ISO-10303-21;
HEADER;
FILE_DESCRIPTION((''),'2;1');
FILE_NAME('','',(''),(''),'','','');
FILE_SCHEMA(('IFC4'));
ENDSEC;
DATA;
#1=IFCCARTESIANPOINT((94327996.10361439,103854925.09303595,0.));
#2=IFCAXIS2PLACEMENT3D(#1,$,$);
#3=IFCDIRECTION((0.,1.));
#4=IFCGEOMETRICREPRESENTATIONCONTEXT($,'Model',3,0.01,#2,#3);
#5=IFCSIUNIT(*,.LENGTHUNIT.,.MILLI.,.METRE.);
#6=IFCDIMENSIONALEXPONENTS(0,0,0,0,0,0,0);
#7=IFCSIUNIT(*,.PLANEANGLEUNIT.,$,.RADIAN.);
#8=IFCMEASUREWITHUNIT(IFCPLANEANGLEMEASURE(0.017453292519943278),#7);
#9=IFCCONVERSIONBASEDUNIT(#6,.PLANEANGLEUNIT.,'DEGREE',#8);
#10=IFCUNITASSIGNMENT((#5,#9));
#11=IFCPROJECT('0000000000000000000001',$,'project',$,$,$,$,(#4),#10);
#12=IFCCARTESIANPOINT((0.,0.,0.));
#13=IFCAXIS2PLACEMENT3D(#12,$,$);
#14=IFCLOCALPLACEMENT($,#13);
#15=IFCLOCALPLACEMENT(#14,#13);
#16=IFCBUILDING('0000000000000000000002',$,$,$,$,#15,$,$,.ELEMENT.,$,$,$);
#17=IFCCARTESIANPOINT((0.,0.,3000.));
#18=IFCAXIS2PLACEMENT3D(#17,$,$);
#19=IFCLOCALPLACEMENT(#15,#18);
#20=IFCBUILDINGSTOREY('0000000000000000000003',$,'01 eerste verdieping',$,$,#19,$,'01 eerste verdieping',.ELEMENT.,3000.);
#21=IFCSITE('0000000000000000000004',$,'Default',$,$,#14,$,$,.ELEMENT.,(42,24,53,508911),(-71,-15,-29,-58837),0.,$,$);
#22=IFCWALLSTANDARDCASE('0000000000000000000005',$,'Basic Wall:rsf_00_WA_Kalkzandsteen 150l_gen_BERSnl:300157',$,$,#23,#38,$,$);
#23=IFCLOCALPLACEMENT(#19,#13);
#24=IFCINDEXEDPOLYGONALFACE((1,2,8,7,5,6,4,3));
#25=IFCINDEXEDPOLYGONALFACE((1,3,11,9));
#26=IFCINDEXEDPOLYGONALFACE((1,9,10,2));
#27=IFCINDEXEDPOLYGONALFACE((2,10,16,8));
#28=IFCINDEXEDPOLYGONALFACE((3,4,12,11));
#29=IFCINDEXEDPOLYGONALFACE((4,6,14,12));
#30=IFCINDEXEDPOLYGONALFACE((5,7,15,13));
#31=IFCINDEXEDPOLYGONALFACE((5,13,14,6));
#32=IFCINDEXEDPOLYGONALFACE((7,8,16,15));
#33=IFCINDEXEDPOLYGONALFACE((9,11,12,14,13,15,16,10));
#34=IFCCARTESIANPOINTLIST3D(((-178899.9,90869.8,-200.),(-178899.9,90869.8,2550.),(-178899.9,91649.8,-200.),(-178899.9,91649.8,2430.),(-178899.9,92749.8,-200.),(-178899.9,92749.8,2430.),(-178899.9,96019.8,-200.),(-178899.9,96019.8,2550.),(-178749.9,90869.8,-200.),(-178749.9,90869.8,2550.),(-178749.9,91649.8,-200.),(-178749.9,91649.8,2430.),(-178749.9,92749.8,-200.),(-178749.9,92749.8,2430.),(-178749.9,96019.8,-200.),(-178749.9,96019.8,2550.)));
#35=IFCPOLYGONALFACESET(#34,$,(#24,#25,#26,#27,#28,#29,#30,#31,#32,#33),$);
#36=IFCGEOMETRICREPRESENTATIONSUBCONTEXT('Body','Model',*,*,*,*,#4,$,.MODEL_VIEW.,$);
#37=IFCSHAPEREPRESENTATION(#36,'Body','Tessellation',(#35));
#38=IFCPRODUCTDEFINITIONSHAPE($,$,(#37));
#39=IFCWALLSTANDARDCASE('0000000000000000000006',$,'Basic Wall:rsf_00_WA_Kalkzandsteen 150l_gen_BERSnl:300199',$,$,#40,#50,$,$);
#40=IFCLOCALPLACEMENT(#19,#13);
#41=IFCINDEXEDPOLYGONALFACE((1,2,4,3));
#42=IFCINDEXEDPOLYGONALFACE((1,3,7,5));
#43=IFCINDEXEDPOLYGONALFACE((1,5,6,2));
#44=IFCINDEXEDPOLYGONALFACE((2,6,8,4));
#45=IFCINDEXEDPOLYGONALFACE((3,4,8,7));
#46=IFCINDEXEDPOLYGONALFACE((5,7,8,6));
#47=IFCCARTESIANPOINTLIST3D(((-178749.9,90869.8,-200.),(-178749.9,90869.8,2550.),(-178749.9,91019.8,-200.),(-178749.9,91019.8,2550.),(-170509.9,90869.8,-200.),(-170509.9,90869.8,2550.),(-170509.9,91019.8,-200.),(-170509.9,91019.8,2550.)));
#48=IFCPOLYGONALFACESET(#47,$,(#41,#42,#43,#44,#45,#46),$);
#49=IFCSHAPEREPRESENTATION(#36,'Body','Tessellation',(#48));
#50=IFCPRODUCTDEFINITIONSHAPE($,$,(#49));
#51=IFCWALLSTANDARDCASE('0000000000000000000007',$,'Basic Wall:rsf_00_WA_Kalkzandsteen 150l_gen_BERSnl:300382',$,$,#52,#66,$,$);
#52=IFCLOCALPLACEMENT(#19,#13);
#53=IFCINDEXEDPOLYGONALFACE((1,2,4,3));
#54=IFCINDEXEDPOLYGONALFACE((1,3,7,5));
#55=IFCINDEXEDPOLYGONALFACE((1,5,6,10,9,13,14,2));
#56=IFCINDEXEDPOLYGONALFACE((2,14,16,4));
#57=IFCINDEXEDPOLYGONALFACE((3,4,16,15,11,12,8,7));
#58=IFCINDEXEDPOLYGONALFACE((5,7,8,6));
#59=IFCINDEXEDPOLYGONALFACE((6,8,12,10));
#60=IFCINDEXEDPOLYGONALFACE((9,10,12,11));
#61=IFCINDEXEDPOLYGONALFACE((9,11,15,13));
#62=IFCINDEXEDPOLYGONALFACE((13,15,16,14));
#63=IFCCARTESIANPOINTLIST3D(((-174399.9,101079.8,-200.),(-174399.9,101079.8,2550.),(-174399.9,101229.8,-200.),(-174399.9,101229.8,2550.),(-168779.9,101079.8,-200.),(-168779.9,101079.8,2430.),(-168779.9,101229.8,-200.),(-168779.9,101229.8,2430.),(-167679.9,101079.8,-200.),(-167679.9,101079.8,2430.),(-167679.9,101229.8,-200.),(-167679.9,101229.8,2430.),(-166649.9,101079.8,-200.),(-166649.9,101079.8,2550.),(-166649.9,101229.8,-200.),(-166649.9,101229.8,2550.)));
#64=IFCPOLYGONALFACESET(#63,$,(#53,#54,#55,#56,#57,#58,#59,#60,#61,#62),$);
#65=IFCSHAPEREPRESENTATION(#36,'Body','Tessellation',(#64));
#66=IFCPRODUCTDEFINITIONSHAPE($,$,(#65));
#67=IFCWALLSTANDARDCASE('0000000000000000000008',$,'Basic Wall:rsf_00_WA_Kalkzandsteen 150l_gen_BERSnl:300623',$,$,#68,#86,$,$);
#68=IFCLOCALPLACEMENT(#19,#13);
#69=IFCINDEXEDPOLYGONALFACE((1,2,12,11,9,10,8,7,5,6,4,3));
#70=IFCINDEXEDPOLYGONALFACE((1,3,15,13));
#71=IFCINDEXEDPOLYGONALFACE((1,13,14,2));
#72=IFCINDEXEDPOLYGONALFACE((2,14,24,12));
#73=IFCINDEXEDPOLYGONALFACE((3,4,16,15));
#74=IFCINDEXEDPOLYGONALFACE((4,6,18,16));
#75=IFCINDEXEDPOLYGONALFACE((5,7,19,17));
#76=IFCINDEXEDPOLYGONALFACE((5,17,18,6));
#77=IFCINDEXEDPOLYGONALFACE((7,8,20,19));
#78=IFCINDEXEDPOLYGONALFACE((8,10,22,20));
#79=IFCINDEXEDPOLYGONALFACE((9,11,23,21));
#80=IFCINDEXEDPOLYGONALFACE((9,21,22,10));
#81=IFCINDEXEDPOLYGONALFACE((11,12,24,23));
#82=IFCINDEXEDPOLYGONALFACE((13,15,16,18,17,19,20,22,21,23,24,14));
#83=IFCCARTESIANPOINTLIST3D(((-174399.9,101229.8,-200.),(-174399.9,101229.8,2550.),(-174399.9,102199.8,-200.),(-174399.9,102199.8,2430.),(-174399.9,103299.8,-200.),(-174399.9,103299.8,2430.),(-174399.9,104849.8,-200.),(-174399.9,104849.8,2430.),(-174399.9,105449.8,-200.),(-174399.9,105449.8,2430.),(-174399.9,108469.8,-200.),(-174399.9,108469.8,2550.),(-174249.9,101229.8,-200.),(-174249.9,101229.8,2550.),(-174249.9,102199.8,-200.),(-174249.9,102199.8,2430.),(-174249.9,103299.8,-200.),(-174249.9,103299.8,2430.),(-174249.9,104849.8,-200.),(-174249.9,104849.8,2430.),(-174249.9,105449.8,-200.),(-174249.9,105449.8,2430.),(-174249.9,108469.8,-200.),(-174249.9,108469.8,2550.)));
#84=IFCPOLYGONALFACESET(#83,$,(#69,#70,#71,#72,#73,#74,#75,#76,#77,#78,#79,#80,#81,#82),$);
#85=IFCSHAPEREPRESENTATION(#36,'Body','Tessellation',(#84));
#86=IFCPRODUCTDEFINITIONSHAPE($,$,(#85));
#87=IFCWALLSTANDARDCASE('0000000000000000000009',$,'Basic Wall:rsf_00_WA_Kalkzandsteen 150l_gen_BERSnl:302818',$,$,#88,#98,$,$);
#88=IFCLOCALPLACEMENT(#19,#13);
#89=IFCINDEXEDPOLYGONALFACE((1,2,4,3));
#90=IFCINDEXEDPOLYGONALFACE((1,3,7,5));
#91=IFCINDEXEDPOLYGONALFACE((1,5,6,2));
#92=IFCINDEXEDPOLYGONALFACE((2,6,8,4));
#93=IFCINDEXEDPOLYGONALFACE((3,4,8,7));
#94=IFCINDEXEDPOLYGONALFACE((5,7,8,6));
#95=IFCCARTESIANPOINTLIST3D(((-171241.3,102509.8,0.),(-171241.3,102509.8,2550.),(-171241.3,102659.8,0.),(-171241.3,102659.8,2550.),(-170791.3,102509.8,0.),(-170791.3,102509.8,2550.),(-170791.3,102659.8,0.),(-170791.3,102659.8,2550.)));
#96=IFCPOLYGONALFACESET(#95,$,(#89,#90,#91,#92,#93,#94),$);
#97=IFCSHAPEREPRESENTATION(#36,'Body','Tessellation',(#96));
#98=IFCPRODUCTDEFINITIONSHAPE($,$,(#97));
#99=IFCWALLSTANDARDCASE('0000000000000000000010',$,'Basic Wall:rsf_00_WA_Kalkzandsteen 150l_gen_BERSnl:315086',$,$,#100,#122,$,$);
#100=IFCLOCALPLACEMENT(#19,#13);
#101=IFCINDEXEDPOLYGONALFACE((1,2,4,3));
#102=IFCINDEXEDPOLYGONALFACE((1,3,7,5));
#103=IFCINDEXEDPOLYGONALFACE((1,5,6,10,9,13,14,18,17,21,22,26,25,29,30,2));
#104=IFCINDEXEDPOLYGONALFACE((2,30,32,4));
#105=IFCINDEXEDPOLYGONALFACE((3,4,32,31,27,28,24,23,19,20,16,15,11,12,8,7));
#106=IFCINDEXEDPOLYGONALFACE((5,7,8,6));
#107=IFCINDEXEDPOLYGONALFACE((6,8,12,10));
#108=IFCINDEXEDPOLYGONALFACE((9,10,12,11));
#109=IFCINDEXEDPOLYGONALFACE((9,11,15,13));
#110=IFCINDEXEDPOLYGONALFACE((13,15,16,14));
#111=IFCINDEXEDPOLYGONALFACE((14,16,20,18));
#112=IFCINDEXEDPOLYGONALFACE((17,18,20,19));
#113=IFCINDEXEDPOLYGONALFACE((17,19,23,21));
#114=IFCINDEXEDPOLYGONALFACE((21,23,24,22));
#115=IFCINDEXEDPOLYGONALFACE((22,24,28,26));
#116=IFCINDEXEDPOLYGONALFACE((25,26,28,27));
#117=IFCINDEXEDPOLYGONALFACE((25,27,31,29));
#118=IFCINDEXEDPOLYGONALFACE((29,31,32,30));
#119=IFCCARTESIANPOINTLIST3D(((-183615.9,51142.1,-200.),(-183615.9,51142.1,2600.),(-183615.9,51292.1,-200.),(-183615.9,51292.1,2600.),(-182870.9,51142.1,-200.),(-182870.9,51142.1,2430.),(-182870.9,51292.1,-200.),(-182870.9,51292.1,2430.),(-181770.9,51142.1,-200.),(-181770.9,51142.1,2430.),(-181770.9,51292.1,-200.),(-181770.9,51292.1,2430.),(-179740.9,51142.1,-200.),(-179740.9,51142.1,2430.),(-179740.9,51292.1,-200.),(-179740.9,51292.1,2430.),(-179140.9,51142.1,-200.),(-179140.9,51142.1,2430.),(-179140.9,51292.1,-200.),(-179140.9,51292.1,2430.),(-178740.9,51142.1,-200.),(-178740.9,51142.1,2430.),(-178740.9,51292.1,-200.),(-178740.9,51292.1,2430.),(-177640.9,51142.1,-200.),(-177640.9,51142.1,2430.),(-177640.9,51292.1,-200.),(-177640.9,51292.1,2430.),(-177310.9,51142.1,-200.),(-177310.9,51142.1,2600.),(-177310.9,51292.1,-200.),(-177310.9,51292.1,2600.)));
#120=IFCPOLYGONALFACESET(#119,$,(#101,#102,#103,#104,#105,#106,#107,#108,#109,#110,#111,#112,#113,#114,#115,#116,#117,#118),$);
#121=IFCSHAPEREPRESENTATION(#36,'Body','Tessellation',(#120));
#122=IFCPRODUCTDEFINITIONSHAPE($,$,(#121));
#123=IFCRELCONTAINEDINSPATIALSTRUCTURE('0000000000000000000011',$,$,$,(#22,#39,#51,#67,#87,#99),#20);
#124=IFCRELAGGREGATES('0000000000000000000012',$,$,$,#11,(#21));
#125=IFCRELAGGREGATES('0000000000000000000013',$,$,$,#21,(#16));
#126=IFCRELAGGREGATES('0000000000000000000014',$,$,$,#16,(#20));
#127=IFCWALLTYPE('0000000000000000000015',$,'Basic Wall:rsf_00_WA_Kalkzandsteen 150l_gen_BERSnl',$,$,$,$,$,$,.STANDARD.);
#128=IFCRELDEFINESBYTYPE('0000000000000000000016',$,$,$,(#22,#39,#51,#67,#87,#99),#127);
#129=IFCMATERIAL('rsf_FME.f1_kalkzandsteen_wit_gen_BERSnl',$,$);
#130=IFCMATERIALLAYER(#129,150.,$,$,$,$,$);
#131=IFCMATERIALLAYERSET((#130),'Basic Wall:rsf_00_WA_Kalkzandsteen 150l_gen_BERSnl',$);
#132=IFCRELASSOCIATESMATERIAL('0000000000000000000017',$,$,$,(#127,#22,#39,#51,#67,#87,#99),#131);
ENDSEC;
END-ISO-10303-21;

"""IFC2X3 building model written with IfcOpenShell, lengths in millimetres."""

from ifc_helpers import new_model, entity, si_unit, converted_unit, direction, frame, frame_2d, origin, origin_2d_with_axis, place, context, subcontext, project, spatial, polyline, rectangle, extrude, clip, bounded_halfspace, material, layer, layer_set, layer_usage, type_object, element, save


model = new_model("IFC2X3")

# Units and contexts
model_context = context("Model", 3, precision=0.01, world=frame((94327996.10361439, 103854925.09303595, 0.0)), true_north=direction((0.0, 1.0)))
body_context = subcontext(model_context, "Body", "Model", "MODEL_VIEW")
ifc_project = project(units=[si_unit("LENGTHUNIT", "METRE", prefix="MILLI"), converted_unit("PLANEANGLEUNIT", "DEGREE", entity("IfcPlaneAngleMeasure", 0.017453292519943278), si_unit("PLANEANGLEUNIT", "RADIAN"), dimensions=[0, 0, 0, 0, 0, 0, 0])], contexts=[model_context])

# Site, building, storey
site_placement = place(None, origin())
site = spatial("IfcSite", under=ifc_project, at=site_placement, Name="Default", CompositionType="ELEMENT", RefLatitude=(42, 24, 53, 508911), RefLongitude=(-71, -15, -29, -58837), RefElevation=0.0)
building_placement = place(site_placement, origin())
building = spatial("IfcBuilding", under=site, at=building_placement, CompositionType="ELEMENT")
storey_placement = place(building_placement, frame((0.0, 0.0, 3000.0)))
storey = spatial("IfcBuildingStorey", under=building, at=storey_placement, Name="01 eerste verdieping", LongName="01 eerste verdieping", CompositionType="ELEMENT", Elevation=3000.0)

# Shared definitions
ifc_material = material(Name="rsf_FME.f1_kalkzandsteen_wit_gen_BERSnl")
ifc_layer = layer(ifc_material, 150.0)
ifc_layer_set = layer_set([ifc_layer], Name="Basic Wall:rsf_00_WA_Kalkzandsteen 150l_gen_BERSnl")
wall_type = type_object("IfcWallType", Name="Basic Wall:rsf_00_WA_Kalkzandsteen 150l_gen_BERSnl", PredefinedType="STANDARD", material=ifc_layer_set)

# Wall, opening
ifc_layer_usage_1 = layer_usage(ifc_layer_set, "AXIS2", "NEGATIVE", 75.0)
wall_1_placement = place(storey_placement, frame((-178824.9, 96019.8, -200.0), z_axis=(0.0, 0.0, 1.0), x_axis=(0.0, -1.0, 0.0)))
wall_1 = element("IfcWallStandardCase", 1, at=wall_1_placement, inside=storey, type_object=wall_type, material=ifc_layer_usage_1, Name="Basic Wall:rsf_00_WA_Kalkzandsteen 150l_gen_BERSnl:300157", context=body_context, shape_type="Clipping", body=[
    clip(extrude(rectangle(XDim=5150.0, YDim=150.0, at=frame_2d((2575.0, 0.0), x_axis=(1.0, 0.0))), origin(), (0.0, 0.0, 1.0), 2750.0), bounded_halfspace(frame((0.0, -75.0, 2750.0), z_axis=(0.0, 0.0, -1.0), x_axis=(-1.0, 0.0, 0.0)), True, frame((0.0, -75.0, 2750.0)), polyline([(0.0, 0.0), (5150.0, 0.0), (5150.0, 150.0), (5000.0, 150.0), (0.0, 150.0), (0.0, 0.0)]))),
])
opening_1_placement = place(wall_1_placement, frame((96019.8, 178824.9, 200.0), z_axis=(0.0, 0.0, 1.0), x_axis=(0.0, 1.0, 0.0)))
element("IfcOpeningElement", 2, at=opening_1_placement, cuts=wall_1, ObjectType="Opening", context=body_context, shape_type="SweptSolid", body=[
    extrude(rectangle(XDim=2630.0, YDim=1100.0, at=frame_2d((0.0, 0.0), x_axis=(0.0, 1.0))), frame((-180423.9, 92199.8, 1115.0), z_axis=(1.0, 0.0, 0.0), x_axis=(0.0, 1.0, 0.0)), (0.0, 0.0, 1.0), 3048.0),
])

# Wall
ifc_layer_usage_2 = layer_usage(ifc_layer_set, "AXIS2", "NEGATIVE", 75.0)
wall_2_placement = place(storey_placement, frame((-178749.9, 90944.8, -200.0)))
element("IfcWallStandardCase", 3, at=wall_2_placement, inside=storey, type_object=wall_type, material=ifc_layer_usage_2, Name="Basic Wall:rsf_00_WA_Kalkzandsteen 150l_gen_BERSnl:300199", context=body_context, shape_type="Clipping", body=[
    clip(extrude(rectangle(XDim=8240.0, YDim=150.0, at=frame_2d((4120.0, 0.0), x_axis=(-1.0, 0.0))), origin(), (0.0, 0.0, 1.0), 2750.0), bounded_halfspace(frame((0.0, -75.0, 2750.0), z_axis=(0.0, 0.0, -1.0), x_axis=(0.0, 1.0, 0.0)), True, frame((0.0, -75.0, 2750.0)), polyline([(0.0, 0.0), (8240.0, 0.0), (8240.0, 150.0), (0.0, 150.0), (0.0, 0.0)]))),
])

# Wall, opening
ifc_layer_usage_3 = layer_usage(ifc_layer_set, "AXIS2", "NEGATIVE", 75.0)
wall_3_placement = place(storey_placement, frame((-174399.9, 101154.8, -200.0)))
wall_3 = element("IfcWallStandardCase", 4, at=wall_3_placement, inside=storey, type_object=wall_type, material=ifc_layer_usage_3, Name="Basic Wall:rsf_00_WA_Kalkzandsteen 150l_gen_BERSnl:300382", context=body_context, shape_type="Clipping", body=[
    clip(extrude(rectangle(XDim=7750.0, YDim=150.0, at=frame_2d((3875.0, 0.0), x_axis=(-1.0, 0.0))), origin(), (0.0, 0.0, 1.0), 2750.0), bounded_halfspace(frame((7750.0, 75.0, 2750.0), z_axis=(0.0, 0.0, -1.0), x_axis=(0.0, 1.0, 0.0)), True, frame((7750.0, 75.0, 2750.0)), polyline([(0.0, 0.0), (-150.0, 0.0), (-7600.0, 0.0), (-7750.0, 0.0), (-7750.0, -150.0), (-3710.0, -150.0), (0.0, -150.0), (0.0, 0.0)]))),
])
opening_2_placement = place(wall_3_placement, frame((174399.9, -101154.8, 200.0)))
element("IfcOpeningElement", 5, at=opening_2_placement, cuts=wall_3, ObjectType="Opening", context=body_context, shape_type="SweptSolid", body=[
    extrude(rectangle(XDim=2630.0, YDim=1100.0, at=frame_2d((0.0, 0.0), x_axis=(1.0, 0.0))), frame((-168229.9, 99705.8, 1115.0), z_axis=(0.0, 1.0, 0.0), x_axis=(0.0, 0.0, 1.0)), (0.0, 0.0, 1.0), 3048.0),
])

# Wall, openings
ifc_layer_usage_4 = layer_usage(ifc_layer_set, "AXIS2", "NEGATIVE", 75.0)
wall_4_placement = place(storey_placement, frame((-174324.9, 108469.8, -200.0), z_axis=(0.0, 0.0, 1.0), x_axis=(0.0, -1.0, 0.0)))
wall_4 = element("IfcWallStandardCase", 6, at=wall_4_placement, inside=storey, type_object=wall_type, material=ifc_layer_usage_4, Name="Basic Wall:rsf_00_WA_Kalkzandsteen 150l_gen_BERSnl:300623", context=body_context, shape_type="Clipping", body=[
    clip(extrude(rectangle(XDim=7240.0, YDim=150.0, at=frame_2d((3620.0, 0.0), x_axis=(1.0, 0.0))), origin(), (0.0, 0.0, 1.0), 2750.0), bounded_halfspace(frame((0.0, -75.0, 2750.0), z_axis=(0.0, 0.0, -1.0), x_axis=(-1.0, 0.0, 0.0)), True, frame((0.0, -75.0, 2750.0)), polyline([(0.0, 0.0), (7240.0, 0.0), (7240.0, 150.0), (0.0, 150.0), (0.0, 0.0)]))),
])
opening_3_placement = place(wall_4_placement, frame((108469.8, 174324.9, 200.0), z_axis=(0.0, 0.0, 1.0), x_axis=(0.0, 1.0, 0.0)))
element("IfcOpeningElement", 7, at=opening_3_placement, cuts=wall_4, ObjectType="Opening", context=body_context, shape_type="SweptSolid", body=[
    extrude(rectangle(XDim=2630.0, YDim=600.0, at=origin_2d_with_axis()), frame((-175773.9, 105149.8, 1115.0), z_axis=(1.0, 0.0, 0.0), x_axis=(0.0, 0.0, 1.0)), (0.0, 0.0, 1.0), 3048.0),
])
opening_4_placement = place(wall_4_placement, frame((108469.8, 174324.9, 200.0), z_axis=(0.0, 0.0, 1.0), x_axis=(0.0, 1.0, 0.0)))
element("IfcOpeningElement", 8, at=opening_4_placement, cuts=wall_4, ObjectType="Opening", context=body_context, shape_type="SweptSolid", body=[
    extrude(rectangle(XDim=2630.0, YDim=1100.0, at=frame_2d((0.0, 0.0), x_axis=(1.0, 0.0))), frame((-175773.9, 102749.8, 1115.0), z_axis=(1.0, 0.0, 0.0), x_axis=(0.0, 0.0, 1.0)), (0.0, 0.0, 1.0), 3048.0),
])

# Wall
ifc_layer_usage_5 = layer_usage(ifc_layer_set, "AXIS2", "NEGATIVE", 75.0)
wall_5_placement = place(storey_placement, frame((-171241.3, 102584.8, 0.0)))
element("IfcWallStandardCase", 9, at=wall_5_placement, inside=storey, type_object=wall_type, material=ifc_layer_usage_5, Name="Basic Wall:rsf_00_WA_Kalkzandsteen 150l_gen_BERSnl:302818", context=body_context, shape_type="Clipping", body=[
    clip(extrude(rectangle(XDim=450.0, YDim=150.0, at=frame_2d((225.0, 0.0), x_axis=(-1.0, 0.0))), origin(), (0.0, 0.0, 1.0), 2550.0), bounded_halfspace(frame((0.0, -75.0, 2550.0), z_axis=(0.0, 0.0, -1.0), x_axis=(0.0, 1.0, 0.0)), True, frame((0.0, -75.0, 2550.0)), polyline([(0.0, 0.0), (450.0, 0.0), (450.0, 150.0), (0.0, 150.0), (0.0, 0.0)]))),
])

# Wall, openings
ifc_layer_usage_6 = layer_usage(ifc_layer_set, "AXIS2", "NEGATIVE", 75.0)
wall_6_placement = place(storey_placement, frame((-177310.9, 51217.1, -200.0), z_axis=(0.0, 0.0, 1.0), x_axis=(-1.0, 0.0, 0.0)))
wall_6 = element("IfcWallStandardCase", 10, at=wall_6_placement, inside=storey, type_object=wall_type, material=ifc_layer_usage_6, Name="Basic Wall:rsf_00_WA_Kalkzandsteen 150l_gen_BERSnl:315086", context=body_context, shape_type="Clipping", body=[
    clip(extrude(rectangle(XDim=6305.0, YDim=150.0, at=frame_2d((3152.5, 0.0), x_axis=(-1.0, 0.0))), origin(), (0.0, 0.0, 1.0), 2800.0), bounded_halfspace(frame((0.0, -75.0, 2800.0), z_axis=(0.0, 0.0, -1.0), x_axis=(0.0, -1.0, 0.0)), True, frame((0.0, -75.0, 2800.0)), polyline([(0.0, 0.0), (6305.0, 0.0), (6305.0, 150.0), (6155.0, 150.0), (3213.5, 150.0), (3063.5, 150.0), (0.0, 150.0), (0.0, 0.0)]))),
])
opening_5_placement = place(wall_6_placement, frame((-177310.9, 51217.1, 200.0), z_axis=(0.0, 0.0, 1.0), x_axis=(-1.0, 0.0, 0.0)))
element("IfcOpeningElement", 11, at=opening_5_placement, cuts=wall_6, ObjectType="Opening", context=body_context, shape_type="SweptSolid", body=[
    extrude(rectangle(XDim=2630.0, YDim=1100.0, at=frame_2d((0.0, 0.0), x_axis=(0.0, 1.0))), frame((-178190.9, 52816.1, 1115.0), z_axis=(0.0, -1.0, 0.0), x_axis=(1.0, 0.0, 0.0)), (0.0, 0.0, 1.0), 3048.0),
])
opening_6_placement = place(wall_6_placement, frame((-177310.9, 51217.1, 200.0), z_axis=(0.0, 0.0, 1.0), x_axis=(-1.0, 0.0, 0.0)))
element("IfcOpeningElement", 12, at=opening_6_placement, cuts=wall_6, ObjectType="Opening", context=body_context, shape_type="SweptSolid", body=[
    extrude(rectangle(XDim=2630.0, YDim=1100.0, at=frame_2d((0.0, 0.0), x_axis=(0.0, 1.0))), frame((-182320.9, 52816.1, 1115.0), z_axis=(0.0, -1.0, 0.0), x_axis=(1.0, 0.0, 0.0)), (0.0, 0.0, 1.0), 3048.0),
])
opening_7_placement = place(wall_6_placement, frame((-177310.9, 51217.1, 200.0), z_axis=(0.0, 0.0, 1.0), x_axis=(-1.0, 0.0, 0.0)))
element("IfcOpeningElement", 13, at=opening_7_placement, cuts=wall_6, ObjectType="Opening", context=body_context, shape_type="SweptSolid", body=[
    extrude(rectangle(XDim=2630.0, YDim=600.0, at=frame_2d((0.0, 0.0), x_axis=(0.0, 1.0))), frame((-179440.9, 52816.1, 1115.0), z_axis=(0.0, -1.0, 0.0), x_axis=(1.0, 0.0, 0.0)), (0.0, 0.0, 1.0), 3048.0),
])

save(model, "model.ifc")
